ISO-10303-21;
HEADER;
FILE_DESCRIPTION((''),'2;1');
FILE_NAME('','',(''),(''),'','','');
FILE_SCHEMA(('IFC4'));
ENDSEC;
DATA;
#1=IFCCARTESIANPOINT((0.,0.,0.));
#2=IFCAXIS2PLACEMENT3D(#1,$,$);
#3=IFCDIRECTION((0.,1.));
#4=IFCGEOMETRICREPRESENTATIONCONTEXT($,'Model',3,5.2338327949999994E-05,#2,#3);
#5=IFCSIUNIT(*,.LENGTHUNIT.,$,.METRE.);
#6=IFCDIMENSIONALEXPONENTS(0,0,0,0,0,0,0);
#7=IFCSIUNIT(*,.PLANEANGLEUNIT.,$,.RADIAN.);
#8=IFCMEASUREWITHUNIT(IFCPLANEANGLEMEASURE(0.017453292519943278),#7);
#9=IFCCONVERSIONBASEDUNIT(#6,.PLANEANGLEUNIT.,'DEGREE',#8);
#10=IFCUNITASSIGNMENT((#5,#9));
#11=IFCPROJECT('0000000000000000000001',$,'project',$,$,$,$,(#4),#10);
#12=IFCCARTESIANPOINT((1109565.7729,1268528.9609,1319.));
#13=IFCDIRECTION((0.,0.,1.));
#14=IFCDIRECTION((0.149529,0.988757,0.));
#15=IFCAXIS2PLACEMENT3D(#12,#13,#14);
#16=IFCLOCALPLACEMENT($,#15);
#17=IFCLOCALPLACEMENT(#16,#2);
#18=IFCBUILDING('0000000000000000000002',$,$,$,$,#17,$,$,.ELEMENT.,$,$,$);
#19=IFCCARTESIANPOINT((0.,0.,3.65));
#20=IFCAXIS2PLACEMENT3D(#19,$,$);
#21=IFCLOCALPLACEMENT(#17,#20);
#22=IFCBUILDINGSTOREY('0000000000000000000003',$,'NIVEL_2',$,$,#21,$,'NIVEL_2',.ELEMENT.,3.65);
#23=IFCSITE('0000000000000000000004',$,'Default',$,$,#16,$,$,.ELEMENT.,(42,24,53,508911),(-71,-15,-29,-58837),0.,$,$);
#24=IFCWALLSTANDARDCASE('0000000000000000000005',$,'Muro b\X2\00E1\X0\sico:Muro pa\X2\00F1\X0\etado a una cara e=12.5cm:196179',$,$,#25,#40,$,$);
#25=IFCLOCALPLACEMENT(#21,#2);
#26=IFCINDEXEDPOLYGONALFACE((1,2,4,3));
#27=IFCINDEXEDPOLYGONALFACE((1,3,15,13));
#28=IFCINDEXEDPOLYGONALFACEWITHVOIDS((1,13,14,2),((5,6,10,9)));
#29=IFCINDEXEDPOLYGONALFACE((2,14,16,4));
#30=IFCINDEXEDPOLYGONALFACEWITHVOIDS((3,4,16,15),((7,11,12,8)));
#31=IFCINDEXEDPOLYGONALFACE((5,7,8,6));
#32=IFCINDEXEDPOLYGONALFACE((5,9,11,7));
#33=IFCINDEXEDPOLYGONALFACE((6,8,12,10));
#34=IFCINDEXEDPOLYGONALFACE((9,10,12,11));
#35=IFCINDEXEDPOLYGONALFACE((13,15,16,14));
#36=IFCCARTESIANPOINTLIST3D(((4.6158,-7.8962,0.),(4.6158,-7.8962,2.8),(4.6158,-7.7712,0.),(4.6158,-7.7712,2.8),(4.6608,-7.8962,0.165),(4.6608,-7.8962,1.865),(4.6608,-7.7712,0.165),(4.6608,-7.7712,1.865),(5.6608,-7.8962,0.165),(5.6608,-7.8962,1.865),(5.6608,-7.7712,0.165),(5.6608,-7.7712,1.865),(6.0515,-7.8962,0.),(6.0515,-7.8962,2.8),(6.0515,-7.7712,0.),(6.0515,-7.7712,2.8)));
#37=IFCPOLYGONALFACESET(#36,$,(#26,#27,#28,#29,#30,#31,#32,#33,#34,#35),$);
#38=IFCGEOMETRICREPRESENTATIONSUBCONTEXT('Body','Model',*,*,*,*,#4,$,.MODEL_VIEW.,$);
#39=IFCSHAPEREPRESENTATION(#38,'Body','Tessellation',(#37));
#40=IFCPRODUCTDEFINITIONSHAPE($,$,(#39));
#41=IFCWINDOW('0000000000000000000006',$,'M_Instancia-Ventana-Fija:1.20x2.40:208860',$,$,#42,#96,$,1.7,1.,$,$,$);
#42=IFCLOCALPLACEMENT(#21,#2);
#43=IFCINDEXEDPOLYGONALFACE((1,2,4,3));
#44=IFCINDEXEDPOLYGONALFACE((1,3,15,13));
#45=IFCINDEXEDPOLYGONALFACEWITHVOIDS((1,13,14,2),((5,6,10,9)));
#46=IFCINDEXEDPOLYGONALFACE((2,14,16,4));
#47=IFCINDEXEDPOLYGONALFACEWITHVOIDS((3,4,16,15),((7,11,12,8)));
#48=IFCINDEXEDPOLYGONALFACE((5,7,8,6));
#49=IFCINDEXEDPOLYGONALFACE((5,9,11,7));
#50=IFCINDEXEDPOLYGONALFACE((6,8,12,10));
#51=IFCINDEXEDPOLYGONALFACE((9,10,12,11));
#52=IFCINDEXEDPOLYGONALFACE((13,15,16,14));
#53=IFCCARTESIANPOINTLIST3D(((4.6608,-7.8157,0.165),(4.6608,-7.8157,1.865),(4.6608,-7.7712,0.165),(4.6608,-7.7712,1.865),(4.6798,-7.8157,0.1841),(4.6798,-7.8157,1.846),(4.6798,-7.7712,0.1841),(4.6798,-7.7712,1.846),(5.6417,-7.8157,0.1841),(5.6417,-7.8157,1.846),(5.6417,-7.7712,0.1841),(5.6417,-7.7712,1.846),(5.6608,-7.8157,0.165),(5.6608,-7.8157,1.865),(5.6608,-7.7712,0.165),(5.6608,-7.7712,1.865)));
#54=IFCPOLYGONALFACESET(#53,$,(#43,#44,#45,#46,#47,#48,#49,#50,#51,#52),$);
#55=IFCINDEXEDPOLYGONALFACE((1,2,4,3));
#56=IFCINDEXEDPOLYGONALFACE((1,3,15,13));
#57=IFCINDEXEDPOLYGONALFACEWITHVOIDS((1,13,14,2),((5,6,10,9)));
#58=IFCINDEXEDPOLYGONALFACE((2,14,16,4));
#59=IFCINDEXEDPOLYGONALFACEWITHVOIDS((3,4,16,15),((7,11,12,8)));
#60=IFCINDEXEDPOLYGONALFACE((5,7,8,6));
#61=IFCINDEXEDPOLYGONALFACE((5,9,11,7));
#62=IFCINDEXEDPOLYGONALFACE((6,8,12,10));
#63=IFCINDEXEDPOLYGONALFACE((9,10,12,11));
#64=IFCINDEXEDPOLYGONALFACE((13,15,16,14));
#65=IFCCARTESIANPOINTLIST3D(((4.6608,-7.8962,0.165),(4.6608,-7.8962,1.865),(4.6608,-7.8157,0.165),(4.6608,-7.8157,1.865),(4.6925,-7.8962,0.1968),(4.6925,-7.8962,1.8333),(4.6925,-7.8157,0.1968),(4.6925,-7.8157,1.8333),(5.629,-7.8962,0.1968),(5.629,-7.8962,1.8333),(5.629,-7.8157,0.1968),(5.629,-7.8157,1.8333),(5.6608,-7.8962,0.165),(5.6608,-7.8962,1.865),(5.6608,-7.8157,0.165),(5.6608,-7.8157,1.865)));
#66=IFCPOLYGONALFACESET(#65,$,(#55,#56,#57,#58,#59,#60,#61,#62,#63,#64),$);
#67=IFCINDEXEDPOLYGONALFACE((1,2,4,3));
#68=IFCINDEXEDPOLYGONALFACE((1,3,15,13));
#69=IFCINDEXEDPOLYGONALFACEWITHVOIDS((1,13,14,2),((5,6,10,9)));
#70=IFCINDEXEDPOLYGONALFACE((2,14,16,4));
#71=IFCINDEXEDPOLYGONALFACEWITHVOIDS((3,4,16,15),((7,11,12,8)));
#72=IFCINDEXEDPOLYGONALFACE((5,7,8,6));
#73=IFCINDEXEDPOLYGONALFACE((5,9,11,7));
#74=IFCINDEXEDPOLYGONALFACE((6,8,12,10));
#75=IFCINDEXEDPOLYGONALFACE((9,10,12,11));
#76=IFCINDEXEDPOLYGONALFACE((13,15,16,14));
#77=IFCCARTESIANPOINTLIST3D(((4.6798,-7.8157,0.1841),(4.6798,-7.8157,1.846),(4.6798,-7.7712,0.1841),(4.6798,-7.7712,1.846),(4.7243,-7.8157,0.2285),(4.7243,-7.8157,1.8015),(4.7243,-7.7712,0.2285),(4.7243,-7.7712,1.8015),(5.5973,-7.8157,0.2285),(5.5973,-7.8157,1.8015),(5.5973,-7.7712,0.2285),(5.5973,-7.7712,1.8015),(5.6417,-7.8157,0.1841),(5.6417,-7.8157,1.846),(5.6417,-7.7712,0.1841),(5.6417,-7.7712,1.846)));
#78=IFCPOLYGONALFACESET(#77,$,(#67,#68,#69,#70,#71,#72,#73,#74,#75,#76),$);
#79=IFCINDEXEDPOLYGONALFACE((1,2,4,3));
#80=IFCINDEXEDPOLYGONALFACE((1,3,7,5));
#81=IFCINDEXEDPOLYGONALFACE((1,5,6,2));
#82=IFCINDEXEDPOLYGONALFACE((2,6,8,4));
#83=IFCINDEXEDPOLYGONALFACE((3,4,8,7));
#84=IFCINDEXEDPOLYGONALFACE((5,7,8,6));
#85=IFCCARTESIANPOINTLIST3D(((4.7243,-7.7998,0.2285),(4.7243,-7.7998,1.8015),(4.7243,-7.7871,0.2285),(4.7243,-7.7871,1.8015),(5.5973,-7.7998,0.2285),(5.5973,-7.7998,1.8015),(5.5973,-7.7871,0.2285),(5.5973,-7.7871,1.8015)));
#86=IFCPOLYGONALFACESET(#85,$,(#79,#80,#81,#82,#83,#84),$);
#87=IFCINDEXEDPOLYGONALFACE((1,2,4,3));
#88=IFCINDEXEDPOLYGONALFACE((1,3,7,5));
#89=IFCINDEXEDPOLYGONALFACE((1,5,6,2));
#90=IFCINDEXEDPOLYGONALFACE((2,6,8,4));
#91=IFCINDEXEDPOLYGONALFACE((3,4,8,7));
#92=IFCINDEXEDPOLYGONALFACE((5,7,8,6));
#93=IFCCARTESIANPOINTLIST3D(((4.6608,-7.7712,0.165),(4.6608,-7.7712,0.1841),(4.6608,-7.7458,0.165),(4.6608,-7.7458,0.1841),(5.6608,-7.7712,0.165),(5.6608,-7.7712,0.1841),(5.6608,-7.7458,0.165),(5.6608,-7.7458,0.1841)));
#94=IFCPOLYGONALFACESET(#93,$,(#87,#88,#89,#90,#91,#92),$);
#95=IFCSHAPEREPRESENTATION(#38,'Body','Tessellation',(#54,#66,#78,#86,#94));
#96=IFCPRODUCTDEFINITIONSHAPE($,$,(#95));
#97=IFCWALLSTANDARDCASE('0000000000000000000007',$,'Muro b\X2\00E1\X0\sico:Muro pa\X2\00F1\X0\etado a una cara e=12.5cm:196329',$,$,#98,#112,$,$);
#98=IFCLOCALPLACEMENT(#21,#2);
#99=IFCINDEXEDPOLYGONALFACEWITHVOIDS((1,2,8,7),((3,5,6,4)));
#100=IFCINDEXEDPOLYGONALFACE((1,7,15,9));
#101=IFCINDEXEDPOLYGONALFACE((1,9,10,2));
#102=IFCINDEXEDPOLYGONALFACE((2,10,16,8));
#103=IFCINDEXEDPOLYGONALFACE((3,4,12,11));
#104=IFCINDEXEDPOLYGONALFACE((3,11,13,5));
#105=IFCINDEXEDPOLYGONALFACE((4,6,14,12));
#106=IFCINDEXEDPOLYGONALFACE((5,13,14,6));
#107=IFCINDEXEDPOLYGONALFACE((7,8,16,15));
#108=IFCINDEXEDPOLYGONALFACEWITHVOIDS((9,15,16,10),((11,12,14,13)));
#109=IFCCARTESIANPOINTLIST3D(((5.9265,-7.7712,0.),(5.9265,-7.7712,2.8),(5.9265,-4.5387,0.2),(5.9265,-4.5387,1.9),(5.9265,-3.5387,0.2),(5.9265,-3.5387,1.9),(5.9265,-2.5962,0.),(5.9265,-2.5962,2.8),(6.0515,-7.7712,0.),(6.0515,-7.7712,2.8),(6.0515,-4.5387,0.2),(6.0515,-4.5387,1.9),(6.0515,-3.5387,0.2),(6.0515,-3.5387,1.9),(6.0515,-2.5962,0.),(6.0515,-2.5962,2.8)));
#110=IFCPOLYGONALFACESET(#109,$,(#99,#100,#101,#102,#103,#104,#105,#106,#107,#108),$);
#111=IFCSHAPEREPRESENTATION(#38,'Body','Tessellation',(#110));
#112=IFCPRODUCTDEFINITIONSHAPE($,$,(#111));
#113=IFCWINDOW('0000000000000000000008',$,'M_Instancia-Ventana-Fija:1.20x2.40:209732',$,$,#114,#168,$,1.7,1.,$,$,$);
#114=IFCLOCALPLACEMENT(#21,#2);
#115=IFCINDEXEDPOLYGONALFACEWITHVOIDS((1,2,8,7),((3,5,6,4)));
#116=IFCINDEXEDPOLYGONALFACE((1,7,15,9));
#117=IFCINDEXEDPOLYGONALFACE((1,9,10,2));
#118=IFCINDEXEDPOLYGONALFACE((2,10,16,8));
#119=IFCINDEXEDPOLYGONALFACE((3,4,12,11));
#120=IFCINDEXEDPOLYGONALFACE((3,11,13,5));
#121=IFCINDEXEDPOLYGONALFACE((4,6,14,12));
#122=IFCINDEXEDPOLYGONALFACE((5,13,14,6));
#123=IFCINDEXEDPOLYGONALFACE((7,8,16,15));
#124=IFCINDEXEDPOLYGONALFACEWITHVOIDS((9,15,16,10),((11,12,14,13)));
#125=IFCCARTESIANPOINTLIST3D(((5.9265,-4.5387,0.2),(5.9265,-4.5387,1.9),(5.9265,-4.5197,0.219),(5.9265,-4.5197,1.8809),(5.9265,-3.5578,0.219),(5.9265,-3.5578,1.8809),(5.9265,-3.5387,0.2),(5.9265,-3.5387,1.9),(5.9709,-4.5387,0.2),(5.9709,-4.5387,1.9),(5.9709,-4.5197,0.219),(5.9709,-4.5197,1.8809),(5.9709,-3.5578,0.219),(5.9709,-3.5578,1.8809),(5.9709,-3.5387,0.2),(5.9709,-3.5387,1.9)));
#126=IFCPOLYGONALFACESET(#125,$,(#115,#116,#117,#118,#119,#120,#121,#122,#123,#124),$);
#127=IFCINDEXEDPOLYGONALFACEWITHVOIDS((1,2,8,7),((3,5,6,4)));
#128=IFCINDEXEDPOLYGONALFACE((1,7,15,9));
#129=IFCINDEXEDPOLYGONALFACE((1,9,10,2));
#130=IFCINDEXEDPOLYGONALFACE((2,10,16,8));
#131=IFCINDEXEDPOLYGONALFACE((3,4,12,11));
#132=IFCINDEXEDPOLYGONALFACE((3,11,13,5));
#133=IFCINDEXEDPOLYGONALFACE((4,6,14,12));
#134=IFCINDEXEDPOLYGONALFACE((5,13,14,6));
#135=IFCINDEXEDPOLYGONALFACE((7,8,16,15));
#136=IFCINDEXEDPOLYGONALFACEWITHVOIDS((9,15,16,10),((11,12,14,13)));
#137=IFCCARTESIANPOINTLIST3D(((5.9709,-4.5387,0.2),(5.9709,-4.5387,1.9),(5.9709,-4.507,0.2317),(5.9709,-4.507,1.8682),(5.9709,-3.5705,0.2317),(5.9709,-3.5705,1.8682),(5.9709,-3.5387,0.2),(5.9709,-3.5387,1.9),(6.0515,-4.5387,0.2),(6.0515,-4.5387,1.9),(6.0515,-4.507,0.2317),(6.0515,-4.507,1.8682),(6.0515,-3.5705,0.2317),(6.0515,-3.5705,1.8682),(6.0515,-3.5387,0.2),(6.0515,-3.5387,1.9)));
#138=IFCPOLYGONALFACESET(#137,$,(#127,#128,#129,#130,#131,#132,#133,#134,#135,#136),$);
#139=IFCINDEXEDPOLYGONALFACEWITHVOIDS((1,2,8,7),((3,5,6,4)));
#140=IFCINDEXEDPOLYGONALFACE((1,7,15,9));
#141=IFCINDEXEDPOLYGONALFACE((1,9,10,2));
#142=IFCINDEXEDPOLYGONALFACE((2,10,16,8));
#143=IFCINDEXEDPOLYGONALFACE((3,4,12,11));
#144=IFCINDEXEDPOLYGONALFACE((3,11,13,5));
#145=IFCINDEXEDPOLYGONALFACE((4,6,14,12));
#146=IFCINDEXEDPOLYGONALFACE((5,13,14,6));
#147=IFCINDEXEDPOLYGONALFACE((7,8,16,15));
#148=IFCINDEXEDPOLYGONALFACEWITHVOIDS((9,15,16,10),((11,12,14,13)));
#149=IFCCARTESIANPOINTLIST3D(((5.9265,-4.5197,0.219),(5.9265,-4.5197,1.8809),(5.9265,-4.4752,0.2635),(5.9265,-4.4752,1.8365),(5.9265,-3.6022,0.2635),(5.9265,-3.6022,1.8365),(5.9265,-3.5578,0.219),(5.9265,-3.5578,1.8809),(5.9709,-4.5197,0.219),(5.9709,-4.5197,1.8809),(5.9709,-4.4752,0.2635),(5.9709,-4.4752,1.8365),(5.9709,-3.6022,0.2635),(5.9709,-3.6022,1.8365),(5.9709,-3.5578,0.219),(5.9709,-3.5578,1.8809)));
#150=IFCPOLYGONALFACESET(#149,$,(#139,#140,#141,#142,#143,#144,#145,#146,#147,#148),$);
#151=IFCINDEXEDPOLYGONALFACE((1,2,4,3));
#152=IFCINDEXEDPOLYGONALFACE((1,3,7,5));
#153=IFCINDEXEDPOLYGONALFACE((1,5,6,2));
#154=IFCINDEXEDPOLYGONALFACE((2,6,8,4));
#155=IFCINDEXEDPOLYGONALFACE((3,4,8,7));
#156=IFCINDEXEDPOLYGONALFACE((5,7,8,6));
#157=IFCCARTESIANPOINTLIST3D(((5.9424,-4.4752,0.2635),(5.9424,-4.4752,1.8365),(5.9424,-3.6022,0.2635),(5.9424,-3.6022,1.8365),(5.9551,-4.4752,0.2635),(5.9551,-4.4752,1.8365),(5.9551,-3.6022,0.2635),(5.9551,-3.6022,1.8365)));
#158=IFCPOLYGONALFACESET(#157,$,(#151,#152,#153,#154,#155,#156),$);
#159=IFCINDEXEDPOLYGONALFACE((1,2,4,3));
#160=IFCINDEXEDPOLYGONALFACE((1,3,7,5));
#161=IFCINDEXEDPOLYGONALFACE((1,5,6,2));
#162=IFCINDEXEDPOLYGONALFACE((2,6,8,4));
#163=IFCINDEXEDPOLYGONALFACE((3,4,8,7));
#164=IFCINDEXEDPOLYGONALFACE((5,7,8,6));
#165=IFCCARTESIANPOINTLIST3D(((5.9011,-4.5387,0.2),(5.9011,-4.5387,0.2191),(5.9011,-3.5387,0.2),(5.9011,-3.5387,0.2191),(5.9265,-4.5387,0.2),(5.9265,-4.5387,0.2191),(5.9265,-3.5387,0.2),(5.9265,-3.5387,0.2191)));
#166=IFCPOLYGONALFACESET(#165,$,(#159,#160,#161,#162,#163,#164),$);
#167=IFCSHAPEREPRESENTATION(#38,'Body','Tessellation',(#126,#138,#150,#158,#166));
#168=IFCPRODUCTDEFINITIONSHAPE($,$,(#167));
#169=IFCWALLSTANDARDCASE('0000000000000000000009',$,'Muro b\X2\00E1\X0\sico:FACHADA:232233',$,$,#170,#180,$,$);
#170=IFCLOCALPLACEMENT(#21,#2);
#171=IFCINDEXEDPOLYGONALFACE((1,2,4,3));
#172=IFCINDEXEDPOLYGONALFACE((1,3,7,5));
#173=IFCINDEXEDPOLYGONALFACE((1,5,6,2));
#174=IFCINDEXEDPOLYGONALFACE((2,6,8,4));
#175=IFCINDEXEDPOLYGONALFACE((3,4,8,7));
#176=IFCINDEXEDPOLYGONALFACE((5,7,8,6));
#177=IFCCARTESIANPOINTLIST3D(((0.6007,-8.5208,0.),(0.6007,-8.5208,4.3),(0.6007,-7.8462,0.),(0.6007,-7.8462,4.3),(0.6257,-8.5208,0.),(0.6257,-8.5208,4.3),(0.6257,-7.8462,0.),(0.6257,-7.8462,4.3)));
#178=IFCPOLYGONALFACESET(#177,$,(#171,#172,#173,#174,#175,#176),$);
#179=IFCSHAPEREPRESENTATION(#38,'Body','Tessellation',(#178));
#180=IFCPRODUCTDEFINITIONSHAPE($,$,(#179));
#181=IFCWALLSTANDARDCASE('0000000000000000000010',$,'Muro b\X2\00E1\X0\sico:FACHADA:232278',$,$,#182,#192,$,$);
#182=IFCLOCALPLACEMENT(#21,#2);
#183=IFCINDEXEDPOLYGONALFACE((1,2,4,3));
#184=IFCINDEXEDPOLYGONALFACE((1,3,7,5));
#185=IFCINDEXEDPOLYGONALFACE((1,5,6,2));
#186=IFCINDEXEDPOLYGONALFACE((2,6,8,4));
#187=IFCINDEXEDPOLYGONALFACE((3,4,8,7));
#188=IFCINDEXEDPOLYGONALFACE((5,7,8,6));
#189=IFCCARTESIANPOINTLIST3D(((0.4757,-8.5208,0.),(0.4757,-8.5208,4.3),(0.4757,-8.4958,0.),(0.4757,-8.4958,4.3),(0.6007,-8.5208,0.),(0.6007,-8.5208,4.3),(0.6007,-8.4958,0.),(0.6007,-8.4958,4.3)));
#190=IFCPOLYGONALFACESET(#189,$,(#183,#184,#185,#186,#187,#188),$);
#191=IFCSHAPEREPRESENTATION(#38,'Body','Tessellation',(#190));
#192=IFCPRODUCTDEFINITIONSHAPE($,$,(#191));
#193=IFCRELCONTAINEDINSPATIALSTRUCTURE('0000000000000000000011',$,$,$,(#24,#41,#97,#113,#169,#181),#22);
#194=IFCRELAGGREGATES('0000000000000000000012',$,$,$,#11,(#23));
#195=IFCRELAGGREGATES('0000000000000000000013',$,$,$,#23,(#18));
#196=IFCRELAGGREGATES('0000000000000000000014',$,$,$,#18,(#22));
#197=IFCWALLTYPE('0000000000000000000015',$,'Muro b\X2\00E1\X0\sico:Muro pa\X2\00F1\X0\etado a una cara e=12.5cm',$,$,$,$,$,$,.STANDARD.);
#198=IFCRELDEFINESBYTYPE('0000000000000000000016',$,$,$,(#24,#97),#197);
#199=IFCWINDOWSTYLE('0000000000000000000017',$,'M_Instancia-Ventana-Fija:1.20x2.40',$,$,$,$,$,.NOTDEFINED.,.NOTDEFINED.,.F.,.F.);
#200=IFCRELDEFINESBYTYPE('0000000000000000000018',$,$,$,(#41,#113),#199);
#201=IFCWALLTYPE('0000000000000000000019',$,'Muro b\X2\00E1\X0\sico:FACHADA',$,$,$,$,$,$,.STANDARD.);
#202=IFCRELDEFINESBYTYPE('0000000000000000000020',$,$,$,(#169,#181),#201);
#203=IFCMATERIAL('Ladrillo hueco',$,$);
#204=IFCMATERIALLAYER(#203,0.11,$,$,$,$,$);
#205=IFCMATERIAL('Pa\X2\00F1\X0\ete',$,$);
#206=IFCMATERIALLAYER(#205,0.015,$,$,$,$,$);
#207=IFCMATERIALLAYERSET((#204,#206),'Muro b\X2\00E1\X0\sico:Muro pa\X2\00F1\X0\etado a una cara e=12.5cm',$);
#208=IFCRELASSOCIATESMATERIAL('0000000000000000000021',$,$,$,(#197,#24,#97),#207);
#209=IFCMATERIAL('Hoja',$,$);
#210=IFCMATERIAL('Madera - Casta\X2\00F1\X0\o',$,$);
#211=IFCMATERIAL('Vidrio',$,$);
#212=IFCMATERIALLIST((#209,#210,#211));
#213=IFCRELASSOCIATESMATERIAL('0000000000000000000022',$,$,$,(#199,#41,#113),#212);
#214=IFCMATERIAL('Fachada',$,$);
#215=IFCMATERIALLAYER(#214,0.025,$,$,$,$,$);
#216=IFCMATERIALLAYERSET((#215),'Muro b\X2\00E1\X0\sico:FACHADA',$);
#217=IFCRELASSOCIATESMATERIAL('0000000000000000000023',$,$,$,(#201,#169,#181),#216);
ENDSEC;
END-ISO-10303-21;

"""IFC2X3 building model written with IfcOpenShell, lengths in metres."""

from ifc_helpers import new_model, entity, si_unit, converted_unit, direction, frame, frame_2d, origin, origin_2d_with_axis, place, context, subcontext, project, spatial, polyline, rectangle, outline, extrude, source, transform, mapped, material, material_list, layer, layer_set, layer_usage, type_object, type_shapes, element, fill, save


model = new_model("IFC2X3")

# Units and contexts
model_context = context("Model", 3, precision=5.2338327949999994e-05, world=origin(), true_north=direction((0.0, 1.0)))
body_context = subcontext(model_context, "Body", "Model", "MODEL_VIEW")
ifc_project = project(units=[si_unit("LENGTHUNIT", "METRE"), converted_unit("PLANEANGLEUNIT", "DEGREE", entity("IfcPlaneAngleMeasure", 0.017453292519943278), si_unit("PLANEANGLEUNIT", "RADIAN"), dimensions=[0, 0, 0, 0, 0, 0, 0])], contexts=[model_context])

# Site, building, storey
site_placement = place(None, frame((1109565.7729, 1268528.9609, 1319.0), z_axis=(0.0, 0.0, 1.0), x_axis=(0.149529, 0.988757, 0.0)))
site = spatial("IfcSite", under=ifc_project, at=site_placement, Name="Default", CompositionType="ELEMENT", RefLatitude=(42, 24, 53, 508911), RefLongitude=(-71, -15, -29, -58837), RefElevation=0.0)
building_placement = place(site_placement, origin())
building = spatial("IfcBuilding", under=site, at=building_placement, CompositionType="ELEMENT")
storey_placement = place(building_placement, frame((0.0, 0.0, 3.65)))
storey = spatial("IfcBuildingStorey", under=building, at=storey_placement, Name="NIVEL_2", LongName="NIVEL_2", CompositionType="ELEMENT", Elevation=3.65)

# Shared definitions
ifc_material_1 = material(Name="Pañete")
ifc_material_2 = material(Name="Ladrillo hueco")
ifc_layer_1 = layer(ifc_material_2, 0.11)
ifc_layer_2 = layer(ifc_material_1, 0.015)
ifc_layer_set_1 = layer_set([ifc_layer_1, ifc_layer_2], Name="Muro básico:Muro pañetado a una cara e=12.5cm")
wall_type_1 = type_object("IfcWallType", Name="Muro básico:Muro pañetado a una cara e=12.5cm", PredefinedType="STANDARD", material=ifc_layer_set_1)

# Shared definitions
ifc_material_3 = material(Name="Hoja")
ifc_material_4 = material(Name="Madera - Castaño")
ifc_material_5 = material(Name="Vidrio")
ifc_material_list = material_list([ifc_material_3, ifc_material_4, ifc_material_5])
window_style = type_object("IfcWindowStyle", Name="M_Instancia-Ventana-Fija:1.20x2.40", ConstructionType="NOTDEFINED", OperationType="NOTDEFINED", ParameterTakesPrecedence=False, Sizeable=False, material=ifc_material_list)
shared_shape = source(origin(), body_context, "Body", "SweptSolid", [
    extrude(outline(polyline([(-0.85, -0.5), (0.85, -0.5), (0.85, 0.5), (-0.85, 0.5), (-0.85, -0.5)]), holes=[polyline([(-0.8309, -0.4809), (-0.8309, 0.481), (0.831, 0.481), (0.831, -0.4809), (-0.8309, -0.4809)])]), frame((0.5, 0.0806, 0.85), z_axis=(0.0, 1.0, 0.0), x_axis=(0.0, 0.0, -1.0)), (0.0, 0.0, 1.0), 0.0444),
    extrude(outline(polyline([(-0.5, -0.85), (0.5, -0.85), (0.5, 0.85), (-0.5, 0.85), (-0.5, -0.85)]), holes=[polyline([(-0.4683, -0.8182), (-0.4683, 0.8183), (0.4682, 0.8183), (0.4682, -0.8182), (-0.4683, -0.8182)])]), frame((0.5, 0.0, 0.85), z_axis=(0.0, 1.0, 0.0), x_axis=(1.0, 0.0, 0.0)), (0.0, 0.0, 1.0), 0.0806),
    extrude(outline(polyline([(-0.4809, -0.831), (0.4809, -0.831), (0.4809, 0.831), (-0.4809, 0.831), (-0.4809, -0.831)]), holes=[polyline([(-0.4365, -0.7865), (-0.4365, 0.7865), (0.4365, 0.7865), (0.4365, -0.7865), (-0.4365, -0.7865)])]), frame((0.5, 0.0806, 0.85), z_axis=(0.0, 1.0, 0.0), x_axis=(1.0, 0.0, 0.0)), (0.0, 0.0, 1.0), 0.0444),
    extrude(rectangle(XDim=0.0127, YDim=0.873, at=frame_2d((0.0, 0.0), x_axis=(1.0, 0.0))), frame((0.5, 0.1028, 0.0635), z_axis=(0.0, 0.0, 1.0), x_axis=(0.0, 1.0, 0.0)), (0.0, 0.0, 1.0), 1.573),
    extrude(rectangle(XDim=0.0254, YDim=1.0, at=origin_2d_with_axis()), frame((0.5, 0.1377, 0.0), z_axis=(0.0, 0.0, 1.0), x_axis=(0.0, -1.0, 0.0)), (0.0, 0.0, 1.0), 0.019),
])
type_shapes(window_style, [shared_shape])

# Walls, openings, windows
ifc_layer_usage_1 = layer_usage(ifc_layer_set_1, "AXIS2", "POSITIVE", -0.0625)
wall_1_placement = place(storey_placement, frame((4.6158, -7.8337, 0.0)))
wall_1 = element("IfcWallStandardCase", 1, at=wall_1_placement, inside=storey, type_object=wall_type_1, material=ifc_layer_usage_1, Name="Muro básico:Muro pañetado a una cara e=12.5cm:196179", context=body_context, shape_type="SweptSolid", body=[
    extrude(rectangle(XDim=1.4357, YDim=0.125, at=frame_2d((0.7179, 0.0), x_axis=(-1.0, 0.0))), origin(), (0.0, 0.0, 1.0), 2.8),
])
opening_1_placement = place(wall_1_placement, frame((0.045, -0.0625, 0.165)))
opening_1 = element("IfcOpeningElement", 2, at=opening_1_placement, cuts=wall_1, ObjectType="Opening", context=body_context, shape_type="SweptSolid", body=[
    extrude(rectangle(XDim=1.7, YDim=1.0, at=frame_2d((0.85, 0.5), x_axis=(-1.0, 0.0))), frame((0.0, 0.0, 0.0), z_axis=(0.0, 1.0, 0.0), x_axis=(0.0, 0.0, 1.0)), (0.0, 0.0, 1.0), 0.125),
])
window_1_placement = place(opening_1_placement, origin())
window_1 = element("IfcWindow", 3, at=window_1_placement, inside=storey, type_object=window_style, material=ifc_material_list, Name="M_Instancia-Ventana-Fija:1.20x2.40:208860", OverallHeight=1.7, OverallWidth=1.0, context=body_context, shape_type="MappedRepresentation", body=[
    mapped(shared_shape, transform((0.0, 0.0, 0.0), scale=1.0)),
])
fill(opening_1, window_1)
ifc_layer_usage_2 = layer_usage(ifc_layer_set_1, "AXIS2", "POSITIVE", -0.0625)
wall_2_placement = place(storey_placement, frame((5.989, -7.7712, 0.0), z_axis=(0.0, 0.0, 1.0), x_axis=(0.0, 1.0, 0.0)))
wall_2 = element("IfcWallStandardCase", 4, at=wall_2_placement, inside=storey, type_object=wall_type_1, material=ifc_layer_usage_2, Name="Muro básico:Muro pañetado a una cara e=12.5cm:196329", context=body_context, shape_type="SweptSolid", body=[
    extrude(rectangle(XDim=5.175, YDim=0.125, at=frame_2d((2.5875, 0.0), x_axis=(-1.0, 0.0))), origin(), (0.0, 0.0, 1.0), 2.8),
])
opening_2_placement = place(wall_2_placement, frame((3.2325, -0.0625, 0.2)))
opening_2 = element("IfcOpeningElement", 5, at=opening_2_placement, cuts=wall_2, ObjectType="Opening", context=body_context, shape_type="SweptSolid", body=[
    extrude(rectangle(XDim=1.7, YDim=1.0, at=frame_2d((0.85, 0.5), x_axis=(-1.0, 0.0))), frame((0.0, 0.0, 0.0), z_axis=(0.0, 1.0, 0.0), x_axis=(0.0, 0.0, 1.0)), (0.0, 0.0, 1.0), 0.125),
])
window_2_placement = place(opening_2_placement, origin())
window_2 = element("IfcWindow", 6, at=window_2_placement, inside=storey, type_object=window_style, material=ifc_material_list, Name="M_Instancia-Ventana-Fija:1.20x2.40:209732", OverallHeight=1.7, OverallWidth=1.0, context=body_context, shape_type="MappedRepresentation", body=[
    mapped(shared_shape, transform((0.0, 0.0, 0.0), scale=1.0)),
])
fill(opening_2, window_2)

# Walls
ifc_material_6 = material(Name="Fachada")
ifc_layer_3 = layer(ifc_material_6, 0.025)
ifc_layer_set_2 = layer_set([ifc_layer_3], Name="Muro básico:FACHADA")
ifc_layer_usage_3 = layer_usage(ifc_layer_set_2, "AXIS2", "NEGATIVE", 0.0125)
wall_type_2 = type_object("IfcWallType", Name="Muro básico:FACHADA", PredefinedType="STANDARD", material=ifc_layer_set_2)
wall_3_placement = place(storey_placement, frame((0.6132, -7.8462, 0.0), z_axis=(0.0, 0.0, 1.0), x_axis=(0.0, -1.0, 0.0)))
element("IfcWallStandardCase", 7, at=wall_3_placement, inside=storey, type_object=wall_type_2, material=ifc_layer_usage_3, Name="Muro básico:FACHADA:232233", context=body_context, shape_type="SweptSolid", body=[
    extrude(rectangle(XDim=0.6746, YDim=0.025, at=frame_2d((0.3373, 0.0), x_axis=(-1.0, 0.0))), origin(), (0.0, 0.0, 1.0), 4.3),
])
ifc_layer_usage_4 = layer_usage(ifc_layer_set_2, "AXIS2", "NEGATIVE", 0.0125)
wall_4_placement = place(storey_placement, frame((0.6007, -8.5083, 0.0), z_axis=(0.0, 0.0, 1.0), x_axis=(-1.0, 0.0, 0.0)))
element("IfcWallStandardCase", 8, at=wall_4_placement, inside=storey, type_object=wall_type_2, material=ifc_layer_usage_4, Name="Muro básico:FACHADA:232278", context=body_context, shape_type="SweptSolid", body=[
    extrude(rectangle(XDim=0.125, YDim=0.025, at=frame_2d((0.0625, 0.0), x_axis=(-1.0, 0.0))), origin(), (0.0, 0.0, 1.0), 4.3),
])

save(model, "model.ifc")
